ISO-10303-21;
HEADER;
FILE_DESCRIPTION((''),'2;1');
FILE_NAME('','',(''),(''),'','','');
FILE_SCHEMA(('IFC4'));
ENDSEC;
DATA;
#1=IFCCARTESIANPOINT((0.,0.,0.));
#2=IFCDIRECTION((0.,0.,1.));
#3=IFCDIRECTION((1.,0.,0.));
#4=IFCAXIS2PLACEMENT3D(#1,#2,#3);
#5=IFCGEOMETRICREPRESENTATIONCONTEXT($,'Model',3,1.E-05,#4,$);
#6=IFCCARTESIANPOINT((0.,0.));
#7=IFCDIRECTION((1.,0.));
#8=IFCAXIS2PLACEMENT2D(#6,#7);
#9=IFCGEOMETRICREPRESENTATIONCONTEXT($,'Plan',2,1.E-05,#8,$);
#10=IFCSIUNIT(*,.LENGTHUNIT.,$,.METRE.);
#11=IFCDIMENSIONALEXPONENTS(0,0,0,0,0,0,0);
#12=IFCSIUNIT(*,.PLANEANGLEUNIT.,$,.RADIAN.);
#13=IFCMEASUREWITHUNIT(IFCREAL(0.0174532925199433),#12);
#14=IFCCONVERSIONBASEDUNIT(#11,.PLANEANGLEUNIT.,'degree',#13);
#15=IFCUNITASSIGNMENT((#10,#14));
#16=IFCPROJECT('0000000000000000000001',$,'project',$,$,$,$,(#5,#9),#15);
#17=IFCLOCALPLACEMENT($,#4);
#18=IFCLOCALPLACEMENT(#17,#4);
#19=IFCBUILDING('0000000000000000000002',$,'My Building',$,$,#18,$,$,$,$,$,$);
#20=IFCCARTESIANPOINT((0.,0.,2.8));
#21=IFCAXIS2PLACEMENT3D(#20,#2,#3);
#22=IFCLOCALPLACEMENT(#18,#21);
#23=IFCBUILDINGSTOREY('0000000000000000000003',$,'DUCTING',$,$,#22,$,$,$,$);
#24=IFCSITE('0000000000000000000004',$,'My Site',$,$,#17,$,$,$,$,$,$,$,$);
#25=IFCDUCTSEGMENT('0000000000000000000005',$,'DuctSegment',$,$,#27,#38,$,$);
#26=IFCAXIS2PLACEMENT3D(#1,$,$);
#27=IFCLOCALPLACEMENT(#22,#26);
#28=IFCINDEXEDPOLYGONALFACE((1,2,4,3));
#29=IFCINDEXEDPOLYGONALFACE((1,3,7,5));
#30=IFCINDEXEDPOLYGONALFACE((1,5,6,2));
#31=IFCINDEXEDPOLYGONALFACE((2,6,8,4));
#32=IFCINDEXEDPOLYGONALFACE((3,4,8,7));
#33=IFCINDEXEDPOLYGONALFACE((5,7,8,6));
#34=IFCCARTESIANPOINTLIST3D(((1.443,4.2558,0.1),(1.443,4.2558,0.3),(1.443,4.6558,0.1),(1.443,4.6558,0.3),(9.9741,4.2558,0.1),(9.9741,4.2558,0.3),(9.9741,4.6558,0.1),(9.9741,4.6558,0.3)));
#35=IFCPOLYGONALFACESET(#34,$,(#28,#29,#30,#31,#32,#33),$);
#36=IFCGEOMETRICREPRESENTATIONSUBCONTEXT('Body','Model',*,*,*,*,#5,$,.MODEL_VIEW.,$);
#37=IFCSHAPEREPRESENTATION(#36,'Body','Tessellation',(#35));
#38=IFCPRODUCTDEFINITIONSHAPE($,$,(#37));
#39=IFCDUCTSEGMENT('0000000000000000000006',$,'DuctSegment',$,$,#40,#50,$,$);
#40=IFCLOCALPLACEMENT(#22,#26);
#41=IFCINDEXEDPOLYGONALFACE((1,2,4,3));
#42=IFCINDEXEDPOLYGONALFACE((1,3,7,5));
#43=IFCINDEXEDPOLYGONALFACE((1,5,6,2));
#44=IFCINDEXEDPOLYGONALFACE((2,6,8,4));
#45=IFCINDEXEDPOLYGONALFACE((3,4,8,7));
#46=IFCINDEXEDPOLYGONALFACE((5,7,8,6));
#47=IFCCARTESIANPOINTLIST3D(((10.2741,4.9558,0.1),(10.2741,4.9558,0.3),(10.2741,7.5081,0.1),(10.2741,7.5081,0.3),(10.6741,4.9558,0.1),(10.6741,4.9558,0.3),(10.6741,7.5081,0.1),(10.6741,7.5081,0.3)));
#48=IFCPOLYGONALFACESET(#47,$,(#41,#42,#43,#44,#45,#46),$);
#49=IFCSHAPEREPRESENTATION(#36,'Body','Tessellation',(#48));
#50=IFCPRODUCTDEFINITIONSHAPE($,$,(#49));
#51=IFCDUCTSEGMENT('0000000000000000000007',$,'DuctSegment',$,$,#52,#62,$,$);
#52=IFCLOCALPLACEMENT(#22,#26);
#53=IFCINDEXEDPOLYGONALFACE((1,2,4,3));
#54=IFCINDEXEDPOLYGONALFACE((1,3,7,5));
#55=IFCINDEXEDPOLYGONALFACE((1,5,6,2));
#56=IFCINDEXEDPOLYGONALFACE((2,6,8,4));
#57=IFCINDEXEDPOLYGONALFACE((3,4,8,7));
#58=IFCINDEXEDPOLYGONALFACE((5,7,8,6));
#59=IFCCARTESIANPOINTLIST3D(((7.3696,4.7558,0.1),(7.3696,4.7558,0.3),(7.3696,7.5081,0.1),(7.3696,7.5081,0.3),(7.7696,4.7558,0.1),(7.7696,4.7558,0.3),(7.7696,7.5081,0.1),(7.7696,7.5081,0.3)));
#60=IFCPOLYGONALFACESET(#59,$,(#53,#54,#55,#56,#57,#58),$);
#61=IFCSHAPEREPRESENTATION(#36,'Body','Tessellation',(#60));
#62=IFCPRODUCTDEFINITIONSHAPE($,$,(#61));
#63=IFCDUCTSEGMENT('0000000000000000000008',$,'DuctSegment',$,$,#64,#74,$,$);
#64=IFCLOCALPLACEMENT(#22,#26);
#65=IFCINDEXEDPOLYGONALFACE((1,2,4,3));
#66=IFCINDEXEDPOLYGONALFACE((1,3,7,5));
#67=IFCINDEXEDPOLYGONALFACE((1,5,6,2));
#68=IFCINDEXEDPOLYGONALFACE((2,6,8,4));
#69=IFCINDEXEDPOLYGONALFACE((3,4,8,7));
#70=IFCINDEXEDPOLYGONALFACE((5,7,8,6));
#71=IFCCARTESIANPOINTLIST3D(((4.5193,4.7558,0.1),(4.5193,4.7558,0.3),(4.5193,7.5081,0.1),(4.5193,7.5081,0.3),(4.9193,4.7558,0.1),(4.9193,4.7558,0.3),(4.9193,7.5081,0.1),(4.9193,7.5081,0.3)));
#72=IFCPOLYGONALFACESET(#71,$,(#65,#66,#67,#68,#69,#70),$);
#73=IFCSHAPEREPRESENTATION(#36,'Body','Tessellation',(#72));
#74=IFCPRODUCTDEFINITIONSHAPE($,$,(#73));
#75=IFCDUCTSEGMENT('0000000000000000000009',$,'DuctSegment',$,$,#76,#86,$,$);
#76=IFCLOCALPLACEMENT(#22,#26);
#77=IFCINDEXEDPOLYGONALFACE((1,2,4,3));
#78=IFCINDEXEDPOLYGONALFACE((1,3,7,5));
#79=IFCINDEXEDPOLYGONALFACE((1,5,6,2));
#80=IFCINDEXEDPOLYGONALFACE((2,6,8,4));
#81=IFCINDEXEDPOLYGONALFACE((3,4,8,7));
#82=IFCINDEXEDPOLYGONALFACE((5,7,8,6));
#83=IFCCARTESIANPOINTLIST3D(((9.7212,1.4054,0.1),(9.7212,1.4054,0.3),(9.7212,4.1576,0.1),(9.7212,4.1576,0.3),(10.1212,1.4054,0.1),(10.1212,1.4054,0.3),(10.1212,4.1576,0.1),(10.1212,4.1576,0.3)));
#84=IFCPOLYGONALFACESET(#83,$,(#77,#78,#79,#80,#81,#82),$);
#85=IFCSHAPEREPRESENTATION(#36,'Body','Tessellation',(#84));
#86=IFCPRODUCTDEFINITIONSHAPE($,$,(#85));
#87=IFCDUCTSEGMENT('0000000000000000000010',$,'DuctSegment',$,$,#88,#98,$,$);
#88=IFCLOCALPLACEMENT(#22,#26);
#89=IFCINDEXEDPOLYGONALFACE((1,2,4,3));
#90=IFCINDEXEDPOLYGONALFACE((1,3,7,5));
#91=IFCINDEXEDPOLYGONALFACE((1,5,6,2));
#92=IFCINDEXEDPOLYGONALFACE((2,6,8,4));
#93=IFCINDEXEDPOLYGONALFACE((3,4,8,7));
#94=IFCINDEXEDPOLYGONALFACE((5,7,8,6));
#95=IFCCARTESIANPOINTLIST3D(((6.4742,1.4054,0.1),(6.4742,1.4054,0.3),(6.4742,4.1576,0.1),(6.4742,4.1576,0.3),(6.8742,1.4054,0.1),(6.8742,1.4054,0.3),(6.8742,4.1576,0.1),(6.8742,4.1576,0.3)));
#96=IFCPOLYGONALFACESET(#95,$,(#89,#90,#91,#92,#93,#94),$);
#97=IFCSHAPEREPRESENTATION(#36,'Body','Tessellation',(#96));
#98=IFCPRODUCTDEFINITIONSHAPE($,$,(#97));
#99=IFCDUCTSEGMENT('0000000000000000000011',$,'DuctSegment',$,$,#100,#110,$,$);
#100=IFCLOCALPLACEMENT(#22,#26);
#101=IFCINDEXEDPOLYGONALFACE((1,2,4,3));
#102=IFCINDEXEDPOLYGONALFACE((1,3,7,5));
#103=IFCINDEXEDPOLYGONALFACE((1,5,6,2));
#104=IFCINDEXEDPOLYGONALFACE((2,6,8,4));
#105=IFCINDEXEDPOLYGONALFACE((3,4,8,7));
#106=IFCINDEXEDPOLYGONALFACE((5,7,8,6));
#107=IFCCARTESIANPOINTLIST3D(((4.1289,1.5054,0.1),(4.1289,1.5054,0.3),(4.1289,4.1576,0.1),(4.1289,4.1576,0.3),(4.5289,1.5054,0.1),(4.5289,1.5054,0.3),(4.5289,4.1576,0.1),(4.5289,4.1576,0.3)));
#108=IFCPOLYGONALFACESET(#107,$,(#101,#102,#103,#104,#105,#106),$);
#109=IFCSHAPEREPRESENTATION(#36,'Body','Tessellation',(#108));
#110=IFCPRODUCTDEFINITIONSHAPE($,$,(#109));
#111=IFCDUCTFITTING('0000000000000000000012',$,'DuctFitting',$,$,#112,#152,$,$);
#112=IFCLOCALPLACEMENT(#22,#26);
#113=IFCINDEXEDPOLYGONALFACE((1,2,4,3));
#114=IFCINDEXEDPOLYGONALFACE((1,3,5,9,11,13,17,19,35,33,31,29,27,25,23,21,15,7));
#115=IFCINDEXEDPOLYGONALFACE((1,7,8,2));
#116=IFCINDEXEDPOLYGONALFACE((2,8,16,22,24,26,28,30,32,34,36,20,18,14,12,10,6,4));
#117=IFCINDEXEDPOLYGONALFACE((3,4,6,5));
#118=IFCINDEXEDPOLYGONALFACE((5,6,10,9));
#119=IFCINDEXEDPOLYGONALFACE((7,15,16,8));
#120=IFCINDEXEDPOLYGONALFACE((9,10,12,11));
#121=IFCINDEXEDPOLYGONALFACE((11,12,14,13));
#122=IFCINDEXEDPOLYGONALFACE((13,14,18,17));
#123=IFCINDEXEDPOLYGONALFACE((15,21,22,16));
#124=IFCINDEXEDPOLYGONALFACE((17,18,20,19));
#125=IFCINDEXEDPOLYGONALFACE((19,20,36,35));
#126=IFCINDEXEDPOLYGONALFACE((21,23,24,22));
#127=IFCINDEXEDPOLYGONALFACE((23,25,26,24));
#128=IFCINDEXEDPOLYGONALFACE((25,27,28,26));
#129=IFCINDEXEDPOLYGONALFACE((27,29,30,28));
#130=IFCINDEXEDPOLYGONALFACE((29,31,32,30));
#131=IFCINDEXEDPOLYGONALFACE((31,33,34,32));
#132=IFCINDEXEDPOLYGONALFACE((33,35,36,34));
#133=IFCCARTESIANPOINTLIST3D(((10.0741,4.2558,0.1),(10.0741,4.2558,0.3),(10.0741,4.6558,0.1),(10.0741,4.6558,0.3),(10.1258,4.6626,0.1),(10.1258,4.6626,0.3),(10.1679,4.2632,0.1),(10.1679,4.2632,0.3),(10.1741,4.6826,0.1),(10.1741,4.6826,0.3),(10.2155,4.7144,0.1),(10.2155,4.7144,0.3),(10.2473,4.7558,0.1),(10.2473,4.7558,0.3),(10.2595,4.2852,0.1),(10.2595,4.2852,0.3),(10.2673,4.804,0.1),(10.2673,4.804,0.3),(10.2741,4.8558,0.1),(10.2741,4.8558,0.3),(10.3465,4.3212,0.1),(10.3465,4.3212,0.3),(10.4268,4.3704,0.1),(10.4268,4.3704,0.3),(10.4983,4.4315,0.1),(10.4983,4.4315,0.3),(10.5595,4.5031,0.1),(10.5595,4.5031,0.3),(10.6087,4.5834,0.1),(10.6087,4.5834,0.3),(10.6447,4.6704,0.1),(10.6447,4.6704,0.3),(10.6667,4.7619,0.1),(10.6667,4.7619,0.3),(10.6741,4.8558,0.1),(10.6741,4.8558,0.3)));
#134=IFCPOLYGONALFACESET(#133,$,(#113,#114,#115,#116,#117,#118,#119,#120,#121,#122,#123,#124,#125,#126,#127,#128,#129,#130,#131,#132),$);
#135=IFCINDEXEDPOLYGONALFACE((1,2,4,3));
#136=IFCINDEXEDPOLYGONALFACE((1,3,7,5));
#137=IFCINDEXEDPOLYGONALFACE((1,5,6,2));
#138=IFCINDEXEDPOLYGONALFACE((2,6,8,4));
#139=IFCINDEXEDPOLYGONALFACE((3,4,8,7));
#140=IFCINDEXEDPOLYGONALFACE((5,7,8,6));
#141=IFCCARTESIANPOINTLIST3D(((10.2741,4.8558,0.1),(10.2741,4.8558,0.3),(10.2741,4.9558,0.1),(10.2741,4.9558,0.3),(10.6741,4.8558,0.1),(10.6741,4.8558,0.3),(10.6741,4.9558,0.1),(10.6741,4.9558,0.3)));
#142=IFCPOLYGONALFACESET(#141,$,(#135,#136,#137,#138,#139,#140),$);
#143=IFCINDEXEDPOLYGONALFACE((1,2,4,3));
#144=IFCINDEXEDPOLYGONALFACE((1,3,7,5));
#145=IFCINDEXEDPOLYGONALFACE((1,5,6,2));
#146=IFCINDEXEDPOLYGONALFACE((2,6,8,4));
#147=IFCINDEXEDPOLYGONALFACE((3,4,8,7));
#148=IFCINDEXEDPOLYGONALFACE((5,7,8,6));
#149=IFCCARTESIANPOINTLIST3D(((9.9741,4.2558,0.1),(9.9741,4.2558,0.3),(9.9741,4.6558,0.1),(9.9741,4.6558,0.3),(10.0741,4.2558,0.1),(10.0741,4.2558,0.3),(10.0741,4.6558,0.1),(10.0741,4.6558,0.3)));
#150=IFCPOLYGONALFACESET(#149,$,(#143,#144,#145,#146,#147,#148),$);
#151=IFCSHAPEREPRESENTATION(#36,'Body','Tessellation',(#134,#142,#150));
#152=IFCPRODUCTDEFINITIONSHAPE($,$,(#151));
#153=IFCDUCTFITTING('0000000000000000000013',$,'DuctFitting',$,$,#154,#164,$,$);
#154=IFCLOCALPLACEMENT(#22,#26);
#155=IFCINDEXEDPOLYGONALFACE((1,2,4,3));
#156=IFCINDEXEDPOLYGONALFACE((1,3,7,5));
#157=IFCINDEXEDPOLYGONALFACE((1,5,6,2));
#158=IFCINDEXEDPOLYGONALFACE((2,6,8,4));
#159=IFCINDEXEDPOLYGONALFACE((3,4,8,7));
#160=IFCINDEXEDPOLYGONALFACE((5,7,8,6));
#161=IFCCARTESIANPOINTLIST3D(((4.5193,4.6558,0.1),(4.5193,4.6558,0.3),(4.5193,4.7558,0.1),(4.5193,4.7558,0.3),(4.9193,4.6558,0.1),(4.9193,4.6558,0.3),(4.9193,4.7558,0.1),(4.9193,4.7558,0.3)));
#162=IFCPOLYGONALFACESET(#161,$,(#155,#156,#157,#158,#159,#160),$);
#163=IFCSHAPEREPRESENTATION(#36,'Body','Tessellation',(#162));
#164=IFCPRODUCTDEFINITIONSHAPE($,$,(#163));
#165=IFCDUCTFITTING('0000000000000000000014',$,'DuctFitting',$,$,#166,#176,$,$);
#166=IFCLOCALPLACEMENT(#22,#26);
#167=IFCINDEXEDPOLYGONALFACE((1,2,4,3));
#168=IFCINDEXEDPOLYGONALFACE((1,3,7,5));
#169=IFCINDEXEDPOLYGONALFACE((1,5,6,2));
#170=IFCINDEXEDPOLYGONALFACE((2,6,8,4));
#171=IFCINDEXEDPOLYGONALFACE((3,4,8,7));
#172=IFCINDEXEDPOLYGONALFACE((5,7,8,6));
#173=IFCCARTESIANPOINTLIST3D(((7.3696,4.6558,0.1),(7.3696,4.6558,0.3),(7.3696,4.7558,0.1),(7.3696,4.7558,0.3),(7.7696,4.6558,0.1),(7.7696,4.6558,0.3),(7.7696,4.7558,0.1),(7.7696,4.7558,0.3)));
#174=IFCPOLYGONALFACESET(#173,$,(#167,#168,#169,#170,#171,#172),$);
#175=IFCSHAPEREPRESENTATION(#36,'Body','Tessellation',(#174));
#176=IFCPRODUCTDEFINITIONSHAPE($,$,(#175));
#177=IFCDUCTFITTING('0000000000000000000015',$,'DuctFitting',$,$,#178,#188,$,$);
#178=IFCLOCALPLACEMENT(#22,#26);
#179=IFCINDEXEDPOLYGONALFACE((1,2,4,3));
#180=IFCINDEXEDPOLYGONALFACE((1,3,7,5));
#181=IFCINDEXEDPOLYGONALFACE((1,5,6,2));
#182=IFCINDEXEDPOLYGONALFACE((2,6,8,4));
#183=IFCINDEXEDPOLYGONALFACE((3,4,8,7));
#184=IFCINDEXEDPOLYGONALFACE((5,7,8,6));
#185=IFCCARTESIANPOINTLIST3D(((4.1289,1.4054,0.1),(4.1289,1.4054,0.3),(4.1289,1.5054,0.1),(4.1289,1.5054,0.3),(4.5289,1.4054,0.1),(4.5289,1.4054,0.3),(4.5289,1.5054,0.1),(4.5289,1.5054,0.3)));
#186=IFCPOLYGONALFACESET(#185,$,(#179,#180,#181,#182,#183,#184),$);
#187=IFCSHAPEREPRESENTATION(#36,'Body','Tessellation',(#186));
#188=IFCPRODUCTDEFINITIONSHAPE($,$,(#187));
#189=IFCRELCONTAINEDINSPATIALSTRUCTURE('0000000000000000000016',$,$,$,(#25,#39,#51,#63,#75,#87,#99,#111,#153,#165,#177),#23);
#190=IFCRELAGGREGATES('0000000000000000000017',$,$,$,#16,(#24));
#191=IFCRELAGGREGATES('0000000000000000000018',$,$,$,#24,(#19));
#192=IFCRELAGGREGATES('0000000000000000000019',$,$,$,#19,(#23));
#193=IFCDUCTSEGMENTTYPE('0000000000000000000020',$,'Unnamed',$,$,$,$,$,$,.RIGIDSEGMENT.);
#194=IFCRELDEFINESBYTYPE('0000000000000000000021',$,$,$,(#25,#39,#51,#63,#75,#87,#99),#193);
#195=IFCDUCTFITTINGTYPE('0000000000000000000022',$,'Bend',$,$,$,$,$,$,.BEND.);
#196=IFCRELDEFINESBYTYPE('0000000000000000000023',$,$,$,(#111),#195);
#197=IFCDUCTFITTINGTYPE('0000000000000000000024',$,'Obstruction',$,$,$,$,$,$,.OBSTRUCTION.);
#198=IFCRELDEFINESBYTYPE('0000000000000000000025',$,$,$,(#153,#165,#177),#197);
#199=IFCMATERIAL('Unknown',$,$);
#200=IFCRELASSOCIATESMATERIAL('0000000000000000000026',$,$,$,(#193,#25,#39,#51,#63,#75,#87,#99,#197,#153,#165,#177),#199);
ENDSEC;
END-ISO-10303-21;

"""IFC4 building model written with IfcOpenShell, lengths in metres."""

from ifc_helpers import new_model, entity, si_unit, converted_unit, frame, origin_with_axes, origin_2d_with_axis, place, context, subcontext, project, spatial, line, arc, indexed_curve, rectangle, outline, extrude, source, transform, mapped, material, material_profile, profile_set, profile_usage, type_object, type_shapes, element, save


model = new_model("IFC4")

# Units and contexts
model_context = context("Model", 3, precision=1e-05, world=origin_with_axes())
plan_context = context("Plan", 2, precision=1e-05, world=origin_2d_with_axis())
body_context = subcontext(model_context, "Body", "Model", "MODEL_VIEW")
ifc_project = project(units=[si_unit("LENGTHUNIT", "METRE"), converted_unit("PLANEANGLEUNIT", "degree", entity("IfcReal", 0.0174532925199433), si_unit("PLANEANGLEUNIT", "RADIAN"), dimensions=[0, 0, 0, 0, 0, 0, 0])], contexts=[model_context, plan_context])

# Site, building, storey
site_placement = place(None, origin_with_axes())
site = spatial("IfcSite", under=ifc_project, at=site_placement, Name="My Site")
building_placement = place(site_placement, origin_with_axes())
building = spatial("IfcBuilding", under=site, at=building_placement, Name="My Building")
storey_placement = place(building_placement, frame((0.0, 0.0, 2.8), z_axis=(0.0, 0.0, 1.0), x_axis=(1.0, 0.0, 0.0)))
storey = spatial("IfcBuildingStorey", under=building, at=storey_placement, Name="DUCTING")

# Duct segments
ifc_material = material(Name="Unknown")
ifc_material_profile_1 = material_profile(ifc_material, rectangle(XDim=0.4, YDim=0.2))
ifc_profile_set_1 = profile_set([ifc_material_profile_1])
ifc_profile_usage_1 = profile_usage(ifc_profile_set_1, cardinal=5)
duct_segment_type = type_object("IfcDuctSegmentType", Name="Unnamed", PredefinedType="RIGIDSEGMENT", material=ifc_profile_set_1)
duct_segment_1_placement = place(storey_placement, frame((1.443, 4.4558, 0.2), z_axis=(1.0, 0.0, 0.0), x_axis=(0.0, 1.0, 0.0)))
element("IfcDuctSegment", 1, at=duct_segment_1_placement, inside=storey, type_object=duct_segment_type, material=ifc_profile_usage_1, Name="DuctSegment", context=body_context, shape_type="SweptSolid", body=[
    extrude(rectangle(XDim=0.4, YDim=0.2), origin_with_axes(), (0.0, 0.0, 1.0), 8.5311),
])
ifc_profile_usage_2 = profile_usage(ifc_profile_set_1, cardinal=5)
duct_segment_2_placement = place(storey_placement, frame((10.4741, 4.9558, 0.2), z_axis=(0.0, 1.0, 0.0), x_axis=(-1.0, 0.0, 0.0)))
element("IfcDuctSegment", 2, at=duct_segment_2_placement, inside=storey, type_object=duct_segment_type, material=ifc_profile_usage_2, Name="DuctSegment", context=body_context, shape_type="SweptSolid", body=[
    extrude(rectangle(XDim=0.4, YDim=0.2), origin_with_axes(), (0.0, 0.0, 1.0), 2.5523),
])
ifc_profile_usage_3 = profile_usage(ifc_profile_set_1, cardinal=5)
duct_segment_3_placement = place(storey_placement, frame((7.5696, 4.7558, 0.2), z_axis=(0.0, 1.0, 0.0), x_axis=(-1.0, 0.0, 0.0)))
element("IfcDuctSegment", 3, at=duct_segment_3_placement, inside=storey, type_object=duct_segment_type, material=ifc_profile_usage_3, Name="DuctSegment", context=body_context, shape_type="SweptSolid", body=[
    extrude(rectangle(XDim=0.4, YDim=0.2), origin_with_axes(), (0.0, 0.0, 1.0), 2.7523),
])
ifc_profile_usage_4 = profile_usage(ifc_profile_set_1, cardinal=5)
duct_segment_4_placement = place(storey_placement, frame((4.7193, 4.7558, 0.2), z_axis=(0.0, 1.0, 0.0), x_axis=(-1.0, 0.0, 0.0)))
element("IfcDuctSegment", 4, at=duct_segment_4_placement, inside=storey, type_object=duct_segment_type, material=ifc_profile_usage_4, Name="DuctSegment", context=body_context, shape_type="SweptSolid", body=[
    extrude(rectangle(XDim=0.4, YDim=0.2), origin_with_axes(), (0.0, 0.0, 1.0), 2.7523),
])
ifc_profile_usage_5 = profile_usage(ifc_profile_set_1, cardinal=5)
duct_segment_5_placement = place(storey_placement, frame((9.9212, 4.1576, 0.2), z_axis=(0.0, -1.0, 0.0), x_axis=(1.0, 0.0, 0.0)))
element("IfcDuctSegment", 5, at=duct_segment_5_placement, inside=storey, type_object=duct_segment_type, material=ifc_profile_usage_5, Name="DuctSegment", context=body_context, shape_type="SweptSolid", body=[
    extrude(rectangle(XDim=0.4, YDim=0.2), origin_with_axes(), (0.0, 0.0, 1.0), 2.7523),
])
ifc_profile_usage_6 = profile_usage(ifc_profile_set_1, cardinal=5)
duct_segment_6_placement = place(storey_placement, frame((6.6742, 4.1576, 0.2), z_axis=(0.0, -1.0, 0.0), x_axis=(1.0, 0.0, 0.0)))
element("IfcDuctSegment", 6, at=duct_segment_6_placement, inside=storey, type_object=duct_segment_type, material=ifc_profile_usage_6, Name="DuctSegment", context=body_context, shape_type="SweptSolid", body=[
    extrude(rectangle(XDim=0.4, YDim=0.2), origin_with_axes(), (0.0, 0.0, 1.0), 2.7523),
])
ifc_profile_usage_7 = profile_usage(ifc_profile_set_1, cardinal=5)
duct_segment_7_placement = place(storey_placement, frame((4.3289, 4.1576, 0.2), z_axis=(0.0, -1.0, 0.0), x_axis=(1.0, 0.0, 0.0)))
element("IfcDuctSegment", 7, at=duct_segment_7_placement, inside=storey, type_object=duct_segment_type, material=ifc_profile_usage_7, Name="DuctSegment", context=body_context, shape_type="SweptSolid", body=[
    extrude(rectangle(XDim=0.4, YDim=0.2), origin_with_axes(), (0.0, 0.0, 1.0), 2.6523),
])

# Duct fittings
duct_fitting_type_1 = type_object("IfcDuctFittingType", Name="Bend", PredefinedType="BEND")
shared_shape = source(origin_with_axes(), body_context, "Body", "SweptSolid", [
    extrude(outline(indexed_curve([(0.2, 0.0), (0.2586, -0.1414), (0.4, -0.2), (0.4, -0.6), (-0.0243, -0.4243), (-0.2, 0.0)], segments=[arc(1, 2, 3), line(3, 4), arc(4, 5, 6), line(6, 1)])), frame((0.0, -0.1, -0.1), z_axis=(0.0, -1.0, 0.0), x_axis=(1.0, 0.0, 0.0)), (0.0, 0.0, -1.0), 0.2),
    extrude(rectangle(XDim=0.4, YDim=0.2), origin_with_axes(), (0.0, 0.0, -1.0), 0.1),
    extrude(rectangle(XDim=0.4, YDim=0.2), frame((0.4, 0.0, -0.5), z_axis=(1.0, 0.0, 0.0), x_axis=(0.0, 0.0, 1.0)), (0.0, 0.0, 1.0), 0.1),
])
type_shapes(duct_fitting_type_1, [shared_shape])
duct_fitting_1_placement = place(storey_placement, frame((10.4741, 4.9558, 0.2), z_axis=(0.0, 1.0, 0.0), x_axis=(-1.0, 0.0, 0.0)))
element("IfcDuctFitting", 8, at=duct_fitting_1_placement, inside=storey, type_object=duct_fitting_type_1, Name="DuctFitting", context=body_context, shape_type="MappedRepresentation", body=[
    mapped(shared_shape, transform((0.0, 0.0, 0.0), x_axis=(1.0, 0.0, 0.0), y_axis=(0.0, 1.0, 0.0), z_axis=(0.0, 0.0, 1.0), scale=1.0)),
])
ifc_material_profile_2 = material_profile(ifc_material, rectangle(XDim=0.4, YDim=0.2))
ifc_profile_set_2 = profile_set([ifc_material_profile_2])
ifc_profile_usage_8 = profile_usage(ifc_profile_set_2, cardinal=5)
duct_fitting_type_2 = type_object("IfcDuctFittingType", Name="Obstruction", PredefinedType="OBSTRUCTION", material=ifc_profile_set_2)
duct_fitting_2_placement = place(storey_placement, frame((4.7193, 4.6558, 0.2), z_axis=(0.0, 1.0, 0.0), x_axis=(-1.0, 0.0, 0.0)))
element("IfcDuctFitting", 9, at=duct_fitting_2_placement, inside=storey, type_object=duct_fitting_type_2, material=ifc_profile_usage_8, Name="DuctFitting", context=body_context, shape_type="SweptSolid", body=[
    extrude(rectangle(XDim=0.4, YDim=0.2), origin_with_axes(), (0.0, 0.0, 1.0), 0.1),
])
ifc_profile_usage_9 = profile_usage(ifc_profile_set_2, cardinal=5)
duct_fitting_3_placement = place(storey_placement, frame((7.5696, 4.6558, 0.2), z_axis=(0.0, 1.0, 0.0), x_axis=(-1.0, 0.0, 0.0)))
element("IfcDuctFitting", 10, at=duct_fitting_3_placement, inside=storey, type_object=duct_fitting_type_2, material=ifc_profile_usage_9, Name="DuctFitting", context=body_context, shape_type="SweptSolid", body=[
    extrude(rectangle(XDim=0.4, YDim=0.2), origin_with_axes(), (0.0, 0.0, 1.0), 0.1),
])
ifc_profile_usage_10 = profile_usage(ifc_profile_set_2, cardinal=5)
duct_fitting_4_placement = place(storey_placement, frame((4.3289, 1.5054, 0.2), z_axis=(0.0, -1.0, 0.0), x_axis=(1.0, 0.0, 0.0)))
element("IfcDuctFitting", 11, at=duct_fitting_4_placement, inside=storey, type_object=duct_fitting_type_2, material=ifc_profile_usage_10, Name="DuctFitting", context=body_context, shape_type="SweptSolid", body=[
    extrude(rectangle(XDim=0.4, YDim=0.2), origin_with_axes(), (0.0, 0.0, 1.0), 0.1),
])

save(model, "model.ifc")
